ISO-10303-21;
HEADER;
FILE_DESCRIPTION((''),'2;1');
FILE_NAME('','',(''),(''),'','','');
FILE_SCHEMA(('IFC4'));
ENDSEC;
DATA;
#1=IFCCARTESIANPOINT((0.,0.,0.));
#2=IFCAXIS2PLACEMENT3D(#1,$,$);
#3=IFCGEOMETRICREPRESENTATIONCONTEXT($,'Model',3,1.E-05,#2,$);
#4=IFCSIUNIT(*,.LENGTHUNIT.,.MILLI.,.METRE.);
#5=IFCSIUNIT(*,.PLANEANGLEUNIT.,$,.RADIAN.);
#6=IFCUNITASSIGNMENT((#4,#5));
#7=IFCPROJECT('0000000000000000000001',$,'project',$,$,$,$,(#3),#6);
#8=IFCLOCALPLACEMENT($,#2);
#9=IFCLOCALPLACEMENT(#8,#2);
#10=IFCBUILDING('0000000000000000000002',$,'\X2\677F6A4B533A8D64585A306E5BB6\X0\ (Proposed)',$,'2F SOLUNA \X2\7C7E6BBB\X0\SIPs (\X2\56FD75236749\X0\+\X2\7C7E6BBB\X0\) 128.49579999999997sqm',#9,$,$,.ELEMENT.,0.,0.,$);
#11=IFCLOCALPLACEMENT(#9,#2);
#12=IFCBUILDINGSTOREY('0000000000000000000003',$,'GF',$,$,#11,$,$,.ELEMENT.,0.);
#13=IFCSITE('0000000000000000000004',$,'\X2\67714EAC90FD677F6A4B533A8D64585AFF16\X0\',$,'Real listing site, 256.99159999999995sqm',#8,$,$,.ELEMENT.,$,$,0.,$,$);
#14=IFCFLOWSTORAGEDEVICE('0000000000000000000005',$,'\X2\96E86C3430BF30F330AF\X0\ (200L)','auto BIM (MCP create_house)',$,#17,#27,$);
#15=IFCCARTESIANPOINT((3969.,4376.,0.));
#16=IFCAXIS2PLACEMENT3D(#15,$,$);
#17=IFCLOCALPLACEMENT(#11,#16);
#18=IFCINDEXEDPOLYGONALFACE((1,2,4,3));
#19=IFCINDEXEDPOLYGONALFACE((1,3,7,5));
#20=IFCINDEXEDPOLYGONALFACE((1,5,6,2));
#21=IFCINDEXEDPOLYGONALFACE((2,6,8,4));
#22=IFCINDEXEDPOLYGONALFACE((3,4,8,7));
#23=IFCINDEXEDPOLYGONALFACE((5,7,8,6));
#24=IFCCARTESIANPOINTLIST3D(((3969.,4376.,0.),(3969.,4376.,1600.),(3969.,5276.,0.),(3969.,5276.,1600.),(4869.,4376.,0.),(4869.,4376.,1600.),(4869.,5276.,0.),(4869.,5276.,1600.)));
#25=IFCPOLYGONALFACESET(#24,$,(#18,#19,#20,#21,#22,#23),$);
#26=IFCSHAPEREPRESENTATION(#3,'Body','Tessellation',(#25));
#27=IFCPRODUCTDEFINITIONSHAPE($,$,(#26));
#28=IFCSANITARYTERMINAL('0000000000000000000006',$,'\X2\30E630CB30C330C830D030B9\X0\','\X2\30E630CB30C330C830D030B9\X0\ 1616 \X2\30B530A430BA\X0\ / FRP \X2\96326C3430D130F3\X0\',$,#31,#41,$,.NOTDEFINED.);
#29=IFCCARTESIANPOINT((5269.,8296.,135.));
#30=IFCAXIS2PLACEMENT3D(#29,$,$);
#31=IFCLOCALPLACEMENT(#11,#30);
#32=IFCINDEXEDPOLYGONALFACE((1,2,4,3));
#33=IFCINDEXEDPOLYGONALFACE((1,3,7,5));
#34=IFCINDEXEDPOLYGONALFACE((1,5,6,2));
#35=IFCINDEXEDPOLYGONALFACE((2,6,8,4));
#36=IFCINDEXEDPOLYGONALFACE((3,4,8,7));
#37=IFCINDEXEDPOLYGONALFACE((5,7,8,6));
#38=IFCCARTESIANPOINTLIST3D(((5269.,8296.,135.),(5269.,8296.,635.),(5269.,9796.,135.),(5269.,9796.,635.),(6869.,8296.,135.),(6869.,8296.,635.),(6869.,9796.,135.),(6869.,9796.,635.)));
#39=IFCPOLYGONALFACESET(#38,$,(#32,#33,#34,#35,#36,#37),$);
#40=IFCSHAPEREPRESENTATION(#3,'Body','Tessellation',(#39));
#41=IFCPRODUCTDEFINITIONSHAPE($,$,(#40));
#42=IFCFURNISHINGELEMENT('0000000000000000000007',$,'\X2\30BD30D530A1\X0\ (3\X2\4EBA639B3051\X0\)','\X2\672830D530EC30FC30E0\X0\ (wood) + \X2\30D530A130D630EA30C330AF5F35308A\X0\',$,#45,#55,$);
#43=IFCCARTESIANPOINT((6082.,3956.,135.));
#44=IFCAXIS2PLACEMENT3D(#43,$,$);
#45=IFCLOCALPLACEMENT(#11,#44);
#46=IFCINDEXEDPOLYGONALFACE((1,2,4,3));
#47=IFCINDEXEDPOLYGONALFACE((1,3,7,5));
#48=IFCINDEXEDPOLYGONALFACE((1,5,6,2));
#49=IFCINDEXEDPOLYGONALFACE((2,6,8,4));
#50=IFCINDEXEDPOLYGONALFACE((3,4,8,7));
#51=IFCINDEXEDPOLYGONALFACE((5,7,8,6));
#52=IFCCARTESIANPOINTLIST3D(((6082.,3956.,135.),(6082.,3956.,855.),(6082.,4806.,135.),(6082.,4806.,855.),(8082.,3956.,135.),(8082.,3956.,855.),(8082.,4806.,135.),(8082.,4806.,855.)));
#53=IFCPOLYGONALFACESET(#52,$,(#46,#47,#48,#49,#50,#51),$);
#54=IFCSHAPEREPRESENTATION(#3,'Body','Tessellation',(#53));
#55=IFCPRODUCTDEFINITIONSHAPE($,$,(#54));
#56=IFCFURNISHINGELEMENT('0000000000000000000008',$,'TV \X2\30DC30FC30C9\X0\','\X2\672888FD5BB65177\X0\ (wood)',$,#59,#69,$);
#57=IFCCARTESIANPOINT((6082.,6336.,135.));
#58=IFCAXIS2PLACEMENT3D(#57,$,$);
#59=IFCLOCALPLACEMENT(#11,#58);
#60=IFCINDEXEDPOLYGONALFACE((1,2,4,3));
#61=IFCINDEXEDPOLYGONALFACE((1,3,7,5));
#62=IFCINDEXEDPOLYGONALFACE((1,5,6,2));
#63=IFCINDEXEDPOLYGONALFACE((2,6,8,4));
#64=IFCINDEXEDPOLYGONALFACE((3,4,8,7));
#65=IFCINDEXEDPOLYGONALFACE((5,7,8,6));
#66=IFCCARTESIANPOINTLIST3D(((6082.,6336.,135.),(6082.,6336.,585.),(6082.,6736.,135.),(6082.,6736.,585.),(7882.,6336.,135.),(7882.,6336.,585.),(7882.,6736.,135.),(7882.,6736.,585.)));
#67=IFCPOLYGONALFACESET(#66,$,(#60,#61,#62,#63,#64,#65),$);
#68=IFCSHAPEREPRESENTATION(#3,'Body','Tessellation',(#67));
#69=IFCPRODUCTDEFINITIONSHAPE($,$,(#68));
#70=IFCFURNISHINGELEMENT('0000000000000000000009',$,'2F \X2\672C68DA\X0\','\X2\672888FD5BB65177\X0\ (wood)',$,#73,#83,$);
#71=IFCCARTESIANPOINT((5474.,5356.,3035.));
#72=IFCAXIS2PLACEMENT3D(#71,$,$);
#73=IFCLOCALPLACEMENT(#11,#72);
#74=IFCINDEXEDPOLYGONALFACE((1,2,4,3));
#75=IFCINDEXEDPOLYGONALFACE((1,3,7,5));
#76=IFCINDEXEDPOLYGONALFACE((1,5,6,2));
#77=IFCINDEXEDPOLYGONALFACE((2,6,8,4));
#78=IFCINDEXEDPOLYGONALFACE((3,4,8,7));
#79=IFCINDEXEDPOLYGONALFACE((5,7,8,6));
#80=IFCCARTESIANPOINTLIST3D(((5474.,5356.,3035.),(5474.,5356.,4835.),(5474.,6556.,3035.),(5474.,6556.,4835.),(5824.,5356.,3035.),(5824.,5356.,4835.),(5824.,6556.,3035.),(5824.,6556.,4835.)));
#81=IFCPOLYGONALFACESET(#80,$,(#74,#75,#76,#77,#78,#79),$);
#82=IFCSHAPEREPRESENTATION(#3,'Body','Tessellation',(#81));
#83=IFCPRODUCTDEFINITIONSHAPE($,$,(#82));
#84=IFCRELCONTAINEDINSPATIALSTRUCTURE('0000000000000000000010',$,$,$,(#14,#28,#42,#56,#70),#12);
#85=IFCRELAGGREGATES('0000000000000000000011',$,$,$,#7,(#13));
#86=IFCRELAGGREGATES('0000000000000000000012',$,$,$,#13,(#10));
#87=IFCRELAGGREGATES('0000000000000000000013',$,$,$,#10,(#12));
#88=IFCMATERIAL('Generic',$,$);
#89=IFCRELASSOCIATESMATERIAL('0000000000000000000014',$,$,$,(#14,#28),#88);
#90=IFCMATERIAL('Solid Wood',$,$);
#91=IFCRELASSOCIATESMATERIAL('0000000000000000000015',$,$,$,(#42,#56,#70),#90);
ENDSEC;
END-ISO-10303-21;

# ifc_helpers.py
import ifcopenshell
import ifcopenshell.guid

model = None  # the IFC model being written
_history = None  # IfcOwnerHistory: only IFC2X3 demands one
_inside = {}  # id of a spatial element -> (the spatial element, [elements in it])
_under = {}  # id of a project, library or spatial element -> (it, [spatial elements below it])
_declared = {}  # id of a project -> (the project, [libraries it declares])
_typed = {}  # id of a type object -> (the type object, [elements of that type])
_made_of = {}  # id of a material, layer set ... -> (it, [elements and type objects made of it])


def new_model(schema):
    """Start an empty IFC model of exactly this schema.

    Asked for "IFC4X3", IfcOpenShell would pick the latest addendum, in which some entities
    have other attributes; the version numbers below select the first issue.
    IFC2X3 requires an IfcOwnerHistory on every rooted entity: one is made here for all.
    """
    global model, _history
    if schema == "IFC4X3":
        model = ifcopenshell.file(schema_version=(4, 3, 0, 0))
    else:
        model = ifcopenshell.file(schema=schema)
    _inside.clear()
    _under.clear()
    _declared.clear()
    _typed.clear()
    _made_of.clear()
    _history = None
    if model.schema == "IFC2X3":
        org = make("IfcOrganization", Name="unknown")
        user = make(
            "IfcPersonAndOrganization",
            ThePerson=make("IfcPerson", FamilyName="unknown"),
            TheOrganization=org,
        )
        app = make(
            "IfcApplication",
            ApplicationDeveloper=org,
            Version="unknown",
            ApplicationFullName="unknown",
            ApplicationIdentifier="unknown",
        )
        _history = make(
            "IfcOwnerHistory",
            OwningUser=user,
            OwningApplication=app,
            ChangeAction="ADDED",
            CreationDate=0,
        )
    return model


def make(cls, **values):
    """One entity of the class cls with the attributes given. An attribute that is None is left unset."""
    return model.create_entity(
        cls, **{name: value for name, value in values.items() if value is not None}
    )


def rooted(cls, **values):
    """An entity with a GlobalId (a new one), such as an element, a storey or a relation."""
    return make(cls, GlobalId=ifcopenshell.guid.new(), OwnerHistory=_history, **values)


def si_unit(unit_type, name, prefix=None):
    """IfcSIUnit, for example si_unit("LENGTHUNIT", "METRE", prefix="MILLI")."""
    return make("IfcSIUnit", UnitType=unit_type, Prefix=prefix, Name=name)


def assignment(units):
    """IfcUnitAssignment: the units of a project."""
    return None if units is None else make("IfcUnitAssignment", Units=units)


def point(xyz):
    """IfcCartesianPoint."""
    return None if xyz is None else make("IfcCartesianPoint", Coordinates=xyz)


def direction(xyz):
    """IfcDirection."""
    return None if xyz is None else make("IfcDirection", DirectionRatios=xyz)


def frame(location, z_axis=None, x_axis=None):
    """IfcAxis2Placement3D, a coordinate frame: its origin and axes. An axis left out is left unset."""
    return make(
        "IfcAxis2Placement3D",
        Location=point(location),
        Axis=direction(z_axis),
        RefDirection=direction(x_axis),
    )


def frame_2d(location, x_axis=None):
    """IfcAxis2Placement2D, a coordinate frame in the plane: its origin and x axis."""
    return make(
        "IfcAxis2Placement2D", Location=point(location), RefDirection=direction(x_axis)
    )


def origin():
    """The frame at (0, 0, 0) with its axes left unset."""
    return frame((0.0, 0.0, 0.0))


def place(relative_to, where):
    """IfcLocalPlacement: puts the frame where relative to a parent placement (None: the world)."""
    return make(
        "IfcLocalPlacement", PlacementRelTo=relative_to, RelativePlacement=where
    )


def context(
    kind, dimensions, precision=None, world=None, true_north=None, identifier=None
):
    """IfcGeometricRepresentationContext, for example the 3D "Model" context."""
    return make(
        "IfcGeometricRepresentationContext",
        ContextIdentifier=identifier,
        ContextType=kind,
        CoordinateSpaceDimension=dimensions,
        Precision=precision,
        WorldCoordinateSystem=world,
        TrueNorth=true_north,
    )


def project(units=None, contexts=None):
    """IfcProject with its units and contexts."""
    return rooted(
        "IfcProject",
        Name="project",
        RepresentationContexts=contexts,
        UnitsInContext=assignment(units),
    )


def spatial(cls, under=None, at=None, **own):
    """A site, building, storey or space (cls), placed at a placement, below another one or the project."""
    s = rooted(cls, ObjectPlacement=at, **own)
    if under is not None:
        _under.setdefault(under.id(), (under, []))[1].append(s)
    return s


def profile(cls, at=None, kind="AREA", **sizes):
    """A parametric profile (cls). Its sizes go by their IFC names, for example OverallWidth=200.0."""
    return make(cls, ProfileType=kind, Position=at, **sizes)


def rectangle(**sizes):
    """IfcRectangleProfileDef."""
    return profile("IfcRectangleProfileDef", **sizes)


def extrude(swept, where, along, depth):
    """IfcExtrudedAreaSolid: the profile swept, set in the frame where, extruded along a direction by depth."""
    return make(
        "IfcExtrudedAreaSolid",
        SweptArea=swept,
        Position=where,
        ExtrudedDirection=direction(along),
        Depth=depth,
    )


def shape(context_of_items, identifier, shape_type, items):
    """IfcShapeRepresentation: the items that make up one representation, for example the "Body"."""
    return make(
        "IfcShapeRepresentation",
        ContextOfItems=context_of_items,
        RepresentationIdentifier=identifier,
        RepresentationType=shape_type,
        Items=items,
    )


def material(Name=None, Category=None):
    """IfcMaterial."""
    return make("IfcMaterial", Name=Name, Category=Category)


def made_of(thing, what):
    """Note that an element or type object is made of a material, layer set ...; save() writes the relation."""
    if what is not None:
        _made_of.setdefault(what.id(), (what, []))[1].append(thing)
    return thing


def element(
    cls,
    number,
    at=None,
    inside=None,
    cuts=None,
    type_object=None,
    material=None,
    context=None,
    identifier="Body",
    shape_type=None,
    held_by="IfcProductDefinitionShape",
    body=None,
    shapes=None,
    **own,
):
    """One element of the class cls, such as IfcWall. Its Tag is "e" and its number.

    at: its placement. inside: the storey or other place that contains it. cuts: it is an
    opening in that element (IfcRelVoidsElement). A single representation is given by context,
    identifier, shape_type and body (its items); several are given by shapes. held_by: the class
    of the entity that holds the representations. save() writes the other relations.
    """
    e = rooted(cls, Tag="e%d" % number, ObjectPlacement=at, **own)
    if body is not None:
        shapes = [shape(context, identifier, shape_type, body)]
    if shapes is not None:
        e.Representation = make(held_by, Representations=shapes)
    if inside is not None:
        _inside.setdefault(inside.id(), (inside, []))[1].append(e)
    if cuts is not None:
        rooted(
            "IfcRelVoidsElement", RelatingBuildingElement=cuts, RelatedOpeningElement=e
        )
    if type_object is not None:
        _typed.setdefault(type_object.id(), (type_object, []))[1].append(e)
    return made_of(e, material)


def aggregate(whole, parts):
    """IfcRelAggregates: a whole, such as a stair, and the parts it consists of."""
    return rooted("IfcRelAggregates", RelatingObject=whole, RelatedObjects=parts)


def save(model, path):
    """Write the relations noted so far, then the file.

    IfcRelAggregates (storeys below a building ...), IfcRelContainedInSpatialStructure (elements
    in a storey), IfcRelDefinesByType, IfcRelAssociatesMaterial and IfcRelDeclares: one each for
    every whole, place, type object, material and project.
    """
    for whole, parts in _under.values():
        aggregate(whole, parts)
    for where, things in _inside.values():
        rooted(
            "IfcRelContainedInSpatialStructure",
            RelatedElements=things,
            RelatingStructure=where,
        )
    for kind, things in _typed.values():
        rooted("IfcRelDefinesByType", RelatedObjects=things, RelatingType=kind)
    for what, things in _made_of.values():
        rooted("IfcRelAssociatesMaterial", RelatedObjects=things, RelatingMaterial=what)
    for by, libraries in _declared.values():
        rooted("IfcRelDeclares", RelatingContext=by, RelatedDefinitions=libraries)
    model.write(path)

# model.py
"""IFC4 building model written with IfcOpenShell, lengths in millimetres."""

from ifc_helpers import new_model, si_unit, frame, frame_2d, origin, place, context, project, spatial, rectangle, extrude, material, element, save


model = new_model("IFC4")

# Units and contexts
model_context = context("Model", 3, precision=1e-05, world=origin())
ifc_project = project(units=[si_unit("LENGTHUNIT", "METRE", prefix="MILLI"), si_unit("PLANEANGLEUNIT", "RADIAN")], contexts=[model_context])

# Site, building, storey
site_placement = place(None, origin())
site = spatial("IfcSite", under=ifc_project, at=site_placement, Name="東京都板橋区赤塚６", ObjectType="Real listing site, 256.99159999999995sqm", CompositionType="ELEMENT", RefElevation=0.0)
building_placement = place(site_placement, origin())
building = spatial("IfcBuilding", under=site, at=building_placement, Name="板橋区赤塚の家 (Proposed)", ObjectType="2F SOLUNA 籾殻SIPs (国産杉+籾殻) 128.49579999999997sqm", CompositionType="ELEMENT", ElevationOfRefHeight=0.0, ElevationOfTerrain=0.0)
storey_placement = place(building_placement, origin())
storey = spatial("IfcBuildingStorey", under=building, at=storey_placement, Name="GF", CompositionType="ELEMENT", Elevation=0.0)

# Shared definitions
ifc_material_1 = material(Name="Solid Wood")

# Shared definitions
ifc_material_2 = material(Name="Generic")

# Flow storage device
flow_storage_device_placement = place(storey_placement, frame((3969.0, 4376.0, 0.0)))
element("IfcFlowStorageDevice", 1, at=flow_storage_device_placement, inside=storey, material=ifc_material_2, Name="雨水タンク (200L)", Description="auto BIM (MCP create_house)", context=model_context, shape_type="SweptSolid", body=[
    extrude(rectangle(XDim=900.0, YDim=900.0, at=frame_2d((450.0, 450.0))), frame((3969.0, 4376.0, 0.0)), (0.0, 0.0, 1.0), 1600.0),
])

# Sanitary terminal
sanitary_terminal_placement = place(storey_placement, frame((5269.0, 8296.0, 135.0)))
element("IfcSanitaryTerminal", 2, at=sanitary_terminal_placement, inside=storey, material=ifc_material_2, Name="ユニットバス", Description="ユニットバス 1616 サイズ / FRP 防水パン", PredefinedType="NOTDEFINED", context=model_context, shape_type="SweptSolid", body=[
    extrude(rectangle(XDim=1600.0, YDim=1500.0, at=frame_2d((800.0, 750.0))), frame((5269.0, 8296.0, 135.0)), (0.0, 0.0, 1.0), 500.0),
])

# Furnishing elements
furnishing_1_placement = place(storey_placement, frame((6082.0, 3956.0, 135.0)))
element("IfcFurnishingElement", 3, at=furnishing_1_placement, inside=storey, material=ifc_material_1, Name="ソファ (3人掛け)", Description="木フレーム (wood) + ファブリック張り", context=model_context, shape_type="SweptSolid", body=[
    extrude(rectangle(XDim=2000.0, YDim=850.0, at=frame_2d((1000.0, 425.0))), frame((6082.0, 3956.0, 135.0)), (0.0, 0.0, 1.0), 720.0),
])
furnishing_2_placement = place(storey_placement, frame((6082.0, 6336.0, 135.0)))
element("IfcFurnishingElement", 4, at=furnishing_2_placement, inside=storey, material=ifc_material_1, Name="TV ボード", Description="木製家具 (wood)", context=model_context, shape_type="SweptSolid", body=[
    extrude(rectangle(XDim=1800.0, YDim=400.0, at=frame_2d((900.0, 200.0))), frame((6082.0, 6336.0, 135.0)), (0.0, 0.0, 1.0), 450.0),
])
furnishing_3_placement = place(storey_placement, frame((5474.0, 5356.0, 3035.0)))
element("IfcFurnishingElement", 5, at=furnishing_3_placement, inside=storey, material=ifc_material_1, Name="2F 本棚", Description="木製家具 (wood)", context=model_context, shape_type="SweptSolid", body=[
    extrude(rectangle(XDim=350.0, YDim=1200.0, at=frame_2d((175.0, 600.0))), frame((5474.0, 5356.0, 3035.0)), (0.0, 0.0, 1.0), 1800.0),
])

save(model, "model.ifc")
